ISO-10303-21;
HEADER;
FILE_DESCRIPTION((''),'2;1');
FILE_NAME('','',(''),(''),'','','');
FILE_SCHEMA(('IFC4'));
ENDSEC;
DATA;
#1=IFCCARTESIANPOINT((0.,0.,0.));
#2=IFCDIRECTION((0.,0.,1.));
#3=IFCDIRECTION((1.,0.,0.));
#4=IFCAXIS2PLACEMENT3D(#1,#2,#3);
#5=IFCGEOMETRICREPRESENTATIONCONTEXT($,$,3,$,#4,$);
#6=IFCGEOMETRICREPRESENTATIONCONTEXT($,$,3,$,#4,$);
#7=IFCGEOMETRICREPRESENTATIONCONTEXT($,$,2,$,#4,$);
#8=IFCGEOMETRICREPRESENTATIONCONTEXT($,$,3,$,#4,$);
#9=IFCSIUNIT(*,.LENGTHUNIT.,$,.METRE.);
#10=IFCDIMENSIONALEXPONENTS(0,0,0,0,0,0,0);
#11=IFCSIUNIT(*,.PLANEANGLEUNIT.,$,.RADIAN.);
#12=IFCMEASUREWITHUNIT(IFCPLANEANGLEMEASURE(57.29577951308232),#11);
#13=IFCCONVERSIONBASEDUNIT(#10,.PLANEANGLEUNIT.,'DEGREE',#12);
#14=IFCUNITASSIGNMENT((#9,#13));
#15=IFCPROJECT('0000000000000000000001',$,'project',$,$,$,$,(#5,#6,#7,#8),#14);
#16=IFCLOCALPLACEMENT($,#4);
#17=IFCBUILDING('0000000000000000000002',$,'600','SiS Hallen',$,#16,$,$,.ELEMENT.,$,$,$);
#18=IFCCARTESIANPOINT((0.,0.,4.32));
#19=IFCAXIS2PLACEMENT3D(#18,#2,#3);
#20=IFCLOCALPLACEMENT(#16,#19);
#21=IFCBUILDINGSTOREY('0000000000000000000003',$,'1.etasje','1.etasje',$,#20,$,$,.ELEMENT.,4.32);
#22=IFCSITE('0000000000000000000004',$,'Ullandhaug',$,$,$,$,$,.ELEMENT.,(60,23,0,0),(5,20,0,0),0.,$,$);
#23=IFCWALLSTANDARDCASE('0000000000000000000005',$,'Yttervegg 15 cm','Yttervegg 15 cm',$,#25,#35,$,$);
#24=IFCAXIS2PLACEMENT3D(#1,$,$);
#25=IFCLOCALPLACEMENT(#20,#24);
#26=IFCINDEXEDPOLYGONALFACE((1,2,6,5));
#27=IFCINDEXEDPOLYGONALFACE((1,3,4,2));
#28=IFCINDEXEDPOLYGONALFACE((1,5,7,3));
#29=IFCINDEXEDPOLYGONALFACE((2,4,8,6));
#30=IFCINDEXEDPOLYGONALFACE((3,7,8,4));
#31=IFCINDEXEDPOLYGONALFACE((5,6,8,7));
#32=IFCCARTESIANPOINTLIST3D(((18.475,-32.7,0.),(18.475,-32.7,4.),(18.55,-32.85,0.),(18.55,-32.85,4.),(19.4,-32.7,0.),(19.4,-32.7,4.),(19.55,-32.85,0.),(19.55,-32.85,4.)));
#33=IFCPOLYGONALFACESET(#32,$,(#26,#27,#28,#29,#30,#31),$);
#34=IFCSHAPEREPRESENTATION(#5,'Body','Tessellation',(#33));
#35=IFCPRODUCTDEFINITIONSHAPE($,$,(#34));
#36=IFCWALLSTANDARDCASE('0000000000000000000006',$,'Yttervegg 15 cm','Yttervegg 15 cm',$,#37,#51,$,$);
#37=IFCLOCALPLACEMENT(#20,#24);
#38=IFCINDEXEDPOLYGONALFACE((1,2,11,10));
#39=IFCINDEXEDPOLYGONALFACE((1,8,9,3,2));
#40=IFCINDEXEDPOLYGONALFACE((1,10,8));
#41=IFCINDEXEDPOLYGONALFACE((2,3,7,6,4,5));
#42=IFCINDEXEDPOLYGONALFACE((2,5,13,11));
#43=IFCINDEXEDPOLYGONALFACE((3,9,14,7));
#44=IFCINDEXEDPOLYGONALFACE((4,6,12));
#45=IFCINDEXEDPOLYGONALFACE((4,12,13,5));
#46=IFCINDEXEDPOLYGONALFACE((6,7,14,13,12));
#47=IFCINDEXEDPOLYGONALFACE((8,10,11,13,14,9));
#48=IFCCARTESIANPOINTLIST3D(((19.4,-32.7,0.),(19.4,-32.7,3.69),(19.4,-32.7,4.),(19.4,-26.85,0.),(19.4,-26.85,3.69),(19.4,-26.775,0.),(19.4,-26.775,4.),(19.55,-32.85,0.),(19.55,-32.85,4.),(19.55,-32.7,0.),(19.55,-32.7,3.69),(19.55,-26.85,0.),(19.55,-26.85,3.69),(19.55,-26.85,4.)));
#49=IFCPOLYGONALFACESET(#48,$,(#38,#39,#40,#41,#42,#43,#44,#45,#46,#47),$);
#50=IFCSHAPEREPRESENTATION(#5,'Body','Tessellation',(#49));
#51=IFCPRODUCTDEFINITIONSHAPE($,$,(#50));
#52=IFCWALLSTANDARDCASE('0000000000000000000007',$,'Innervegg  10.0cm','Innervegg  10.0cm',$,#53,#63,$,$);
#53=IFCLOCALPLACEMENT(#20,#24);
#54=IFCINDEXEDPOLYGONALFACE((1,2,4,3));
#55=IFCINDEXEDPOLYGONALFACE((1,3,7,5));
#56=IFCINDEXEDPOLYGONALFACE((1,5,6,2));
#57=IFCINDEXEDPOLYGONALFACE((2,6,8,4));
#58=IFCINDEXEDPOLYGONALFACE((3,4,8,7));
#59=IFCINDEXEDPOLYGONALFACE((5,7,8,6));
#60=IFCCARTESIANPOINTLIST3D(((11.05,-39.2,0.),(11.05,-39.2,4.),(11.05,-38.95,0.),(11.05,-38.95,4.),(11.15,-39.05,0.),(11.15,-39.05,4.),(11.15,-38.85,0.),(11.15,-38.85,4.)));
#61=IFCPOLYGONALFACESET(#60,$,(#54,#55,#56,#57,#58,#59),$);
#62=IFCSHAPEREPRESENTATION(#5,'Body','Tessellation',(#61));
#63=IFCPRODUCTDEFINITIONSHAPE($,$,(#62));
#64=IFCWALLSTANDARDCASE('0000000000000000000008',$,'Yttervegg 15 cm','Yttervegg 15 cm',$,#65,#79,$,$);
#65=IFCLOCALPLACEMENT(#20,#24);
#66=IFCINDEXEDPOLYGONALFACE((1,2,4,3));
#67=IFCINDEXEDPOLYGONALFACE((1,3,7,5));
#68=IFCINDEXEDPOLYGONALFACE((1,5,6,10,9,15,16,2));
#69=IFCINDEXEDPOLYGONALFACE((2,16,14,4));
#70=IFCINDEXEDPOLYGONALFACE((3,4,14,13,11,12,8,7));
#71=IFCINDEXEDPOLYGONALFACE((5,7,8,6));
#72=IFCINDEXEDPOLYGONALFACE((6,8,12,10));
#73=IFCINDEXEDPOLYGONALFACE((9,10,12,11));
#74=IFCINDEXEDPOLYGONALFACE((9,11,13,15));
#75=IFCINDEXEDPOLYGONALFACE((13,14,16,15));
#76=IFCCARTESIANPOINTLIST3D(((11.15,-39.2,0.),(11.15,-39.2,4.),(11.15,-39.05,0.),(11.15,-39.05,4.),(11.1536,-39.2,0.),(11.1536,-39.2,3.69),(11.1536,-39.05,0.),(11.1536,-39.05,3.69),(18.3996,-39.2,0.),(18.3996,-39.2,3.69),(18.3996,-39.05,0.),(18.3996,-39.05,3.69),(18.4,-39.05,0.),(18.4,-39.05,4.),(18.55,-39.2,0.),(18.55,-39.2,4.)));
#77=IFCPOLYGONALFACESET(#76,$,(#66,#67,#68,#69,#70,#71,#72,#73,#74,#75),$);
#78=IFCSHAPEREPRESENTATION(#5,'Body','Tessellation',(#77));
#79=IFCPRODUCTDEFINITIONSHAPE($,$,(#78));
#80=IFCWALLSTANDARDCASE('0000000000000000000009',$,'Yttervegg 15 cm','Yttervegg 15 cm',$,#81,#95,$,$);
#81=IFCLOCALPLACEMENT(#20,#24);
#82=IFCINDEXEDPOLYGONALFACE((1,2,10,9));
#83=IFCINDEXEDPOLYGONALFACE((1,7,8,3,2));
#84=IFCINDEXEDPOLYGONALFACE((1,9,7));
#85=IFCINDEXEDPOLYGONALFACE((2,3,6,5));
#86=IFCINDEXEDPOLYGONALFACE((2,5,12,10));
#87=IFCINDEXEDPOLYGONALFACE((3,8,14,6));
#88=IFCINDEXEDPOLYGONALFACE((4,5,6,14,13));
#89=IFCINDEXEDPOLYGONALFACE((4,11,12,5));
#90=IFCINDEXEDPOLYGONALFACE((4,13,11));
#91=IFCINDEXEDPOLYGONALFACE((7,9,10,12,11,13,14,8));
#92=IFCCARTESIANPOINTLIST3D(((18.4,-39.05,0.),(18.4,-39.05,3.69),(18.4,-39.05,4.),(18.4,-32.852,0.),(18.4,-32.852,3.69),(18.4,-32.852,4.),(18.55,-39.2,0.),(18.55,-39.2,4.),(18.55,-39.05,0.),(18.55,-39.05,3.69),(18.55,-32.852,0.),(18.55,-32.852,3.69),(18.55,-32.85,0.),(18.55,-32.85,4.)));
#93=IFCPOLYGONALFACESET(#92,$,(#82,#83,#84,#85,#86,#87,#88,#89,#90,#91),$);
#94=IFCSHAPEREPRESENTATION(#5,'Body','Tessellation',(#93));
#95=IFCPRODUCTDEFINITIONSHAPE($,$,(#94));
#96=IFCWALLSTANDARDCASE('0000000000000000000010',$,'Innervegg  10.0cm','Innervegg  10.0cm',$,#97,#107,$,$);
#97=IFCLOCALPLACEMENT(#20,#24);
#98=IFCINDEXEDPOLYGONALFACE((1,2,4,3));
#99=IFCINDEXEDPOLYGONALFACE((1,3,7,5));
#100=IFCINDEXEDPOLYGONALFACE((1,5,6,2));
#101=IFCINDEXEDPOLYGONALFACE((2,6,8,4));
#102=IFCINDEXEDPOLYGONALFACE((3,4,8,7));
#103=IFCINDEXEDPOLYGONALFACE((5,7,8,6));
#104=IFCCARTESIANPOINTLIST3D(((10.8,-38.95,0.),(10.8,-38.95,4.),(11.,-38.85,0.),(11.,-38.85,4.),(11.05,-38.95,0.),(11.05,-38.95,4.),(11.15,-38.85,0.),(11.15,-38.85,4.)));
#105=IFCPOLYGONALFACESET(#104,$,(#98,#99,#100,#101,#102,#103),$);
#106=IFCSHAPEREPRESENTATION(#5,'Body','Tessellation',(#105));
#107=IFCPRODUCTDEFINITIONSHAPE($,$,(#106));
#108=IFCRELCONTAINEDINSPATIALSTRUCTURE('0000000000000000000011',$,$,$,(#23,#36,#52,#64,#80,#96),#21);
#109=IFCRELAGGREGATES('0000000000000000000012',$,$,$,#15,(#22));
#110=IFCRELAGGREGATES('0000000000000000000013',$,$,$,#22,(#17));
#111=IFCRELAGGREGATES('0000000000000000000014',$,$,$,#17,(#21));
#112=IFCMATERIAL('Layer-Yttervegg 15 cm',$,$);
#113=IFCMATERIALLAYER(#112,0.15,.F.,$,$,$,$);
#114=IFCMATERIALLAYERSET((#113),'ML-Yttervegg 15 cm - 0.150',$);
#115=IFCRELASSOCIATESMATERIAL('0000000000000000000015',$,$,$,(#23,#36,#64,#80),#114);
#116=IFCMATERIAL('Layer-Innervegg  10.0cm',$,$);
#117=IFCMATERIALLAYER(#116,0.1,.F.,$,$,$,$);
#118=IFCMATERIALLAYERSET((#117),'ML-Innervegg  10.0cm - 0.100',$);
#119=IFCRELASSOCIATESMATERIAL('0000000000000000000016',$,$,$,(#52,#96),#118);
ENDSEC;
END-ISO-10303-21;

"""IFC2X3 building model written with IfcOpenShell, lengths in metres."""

from ifc_helpers import new_model, entity, si_unit, converted_unit, frame, origin_with_axes, place, context, project, spatial, polyline, outline, extrude, material, layer, layer_set, layer_usage, element, save


model = new_model("IFC2X3")

# Units and contexts
context_of_model_1 = context(None, 3, world=origin_with_axes())
context_of_model_2 = context(None, 3, world=origin_with_axes())
context_of_model_3 = context(None, 2, world=origin_with_axes())
context_of_model_4 = context(None, 3, world=origin_with_axes())
ifc_project = project(units=[si_unit("LENGTHUNIT", "METRE"), converted_unit("PLANEANGLEUNIT", "DEGREE", entity("IfcPlaneAngleMeasure", 57.29577951308232), si_unit("PLANEANGLEUNIT", "RADIAN"), dimensions=[0, 0, 0, 0, 0, 0, 0])], contexts=[context_of_model_1, context_of_model_2, context_of_model_3, context_of_model_4])

# Site, building, storey
site = spatial("IfcSite", under=ifc_project, Name="Ullandhaug", CompositionType="ELEMENT", RefLatitude=(60, 23, 0, 0), RefLongitude=(5, 20, 0, 0), RefElevation=0.0)
building_placement = place(None, origin_with_axes())
building = spatial("IfcBuilding", under=site, at=building_placement, Name="600", Description="SiS Hallen", CompositionType="ELEMENT")
storey_placement = place(building_placement, frame((0.0, 0.0, 4.32), z_axis=(0.0, 0.0, 1.0), x_axis=(1.0, 0.0, 0.0)))
storey = spatial("IfcBuildingStorey", under=building, at=storey_placement, Name="1.etasje", Description="1.etasje", CompositionType="ELEMENT", Elevation=4.32)

# Wall
ifc_material_1 = material(Name="Layer-Yttervegg 15 cm")
ifc_layer_1 = layer(ifc_material_1, 0.15, ventilated=False)
ifc_layer_set_1 = layer_set([ifc_layer_1], Name="ML-Yttervegg 15 cm - 0.150")
ifc_layer_usage_1 = layer_usage(ifc_layer_set_1, "AXIS2", "POSITIVE", 0.0)
wall_1_placement = place(storey_placement, frame((18.55, -32.85, 0.0), z_axis=(0.0, 0.0, 1.0), x_axis=(1.0, 0.0, 0.0)))
element("IfcWallStandardCase", 1, at=wall_1_placement, inside=storey, material=ifc_layer_usage_1, Name="Yttervegg 15 cm", Description="Yttervegg 15 cm", context=context_of_model_1, shape_type="SweptSolid", body=[
    extrude(outline(polyline([(0.0, 0.0), (1.0, 0.0), (0.85, 0.15), (-0.075, 0.15), (0.0, 0.0)])), origin_with_axes(), (0.0, 0.0, 1.0), 4.0),
])

# Wall, opening
wall_2_placement = place(storey_placement, frame((19.55, -32.85, 0.0), z_axis=(0.0, 0.0, 1.0), x_axis=(0.0, 1.0, 0.0)))
wall_2 = element("IfcWallStandardCase", 2, at=wall_2_placement, inside=storey, material=ifc_layer_usage_1, Name="Yttervegg 15 cm", Description="Yttervegg 15 cm", context=context_of_model_1, shape_type="SweptSolid", body=[
    extrude(outline(polyline([(0.0, 0.0), (6.0, 0.0), (6.075, 0.15), (0.15, 0.15), (0.0, 0.0)])), frame((0.0, 0.0, 0.0), z_axis=(0.0, 0.0, 1.0), x_axis=(1.0, 0.0, 0.0)), (0.0, 0.0, 1.0), 4.0),
])
opening_1_placement = place(wall_2_placement, frame((0.15, 0.15, 0.0), z_axis=(0.0, 0.0, 1.0), x_axis=(1.0, 0.0, 0.0)))
element("IfcOpeningElement", 3, at=opening_1_placement, cuts=wall_2, context=context_of_model_1, shape_type="SweptSolid", body=[
    extrude(outline(polyline([(0.0, 0.0), (3.69, 0.0), (3.69, 5.85), (0.0, 5.85), (0.0, 0.0)])), frame((0.0, 0.0, 0.0), z_axis=(0.0, 1.0, 0.0), x_axis=(0.0, 0.0, 1.0)), (0.0, 0.0, -1.0), 0.15),
])

# Wall
ifc_material_2 = material(Name="Layer-Innervegg  10.0cm")
ifc_layer_2 = layer(ifc_material_2, 0.1, ventilated=False)
ifc_layer_set_2 = layer_set([ifc_layer_2], Name="ML-Innervegg  10.0cm - 0.100")
ifc_layer_usage_2 = layer_usage(ifc_layer_set_2, "AXIS2", "POSITIVE", 0.0)
wall_3_placement = place(storey_placement, frame((11.05, -38.95, 0.0), z_axis=(0.0, 0.0, 1.0), x_axis=(0.0, -1.0, 0.0)))
element("IfcWallStandardCase", 4, at=wall_3_placement, inside=storey, material=ifc_layer_usage_2, Name="Innervegg  10.0cm", Description="Innervegg  10.0cm", context=context_of_model_1, shape_type="SweptSolid", body=[
    extrude(outline(polyline([(0.0, 0.0), (0.25, 0.0), (0.1, 0.1), (-0.1, 0.1), (0.0, 0.0)])), frame((0.0, 0.0, 0.0), z_axis=(0.0, 0.0, 1.0), x_axis=(1.0, 0.0, 0.0)), (0.0, 0.0, 1.0), 4.0),
])

# Walls, openings
wall_4_placement = place(storey_placement, frame((11.15, -39.2, 0.0), z_axis=(0.0, 0.0, 1.0), x_axis=(1.0, 0.0, 0.0)))
wall_4 = element("IfcWallStandardCase", 5, at=wall_4_placement, inside=storey, material=ifc_layer_usage_1, Name="Yttervegg 15 cm", Description="Yttervegg 15 cm", context=context_of_model_1, shape_type="SweptSolid", body=[
    extrude(outline(polyline([(0.0, 0.0), (7.4, 0.0), (7.25, 0.15), (0.0, 0.15), (0.0, 0.0)])), origin_with_axes(), (0.0, 0.0, 1.0), 4.0),
])
opening_2_placement = place(wall_4_placement, frame((0.0036, 0.15, 0.0), z_axis=(0.0, 0.0, 1.0), x_axis=(1.0, 0.0, 0.0)))
element("IfcOpeningElement", 6, at=opening_2_placement, cuts=wall_4, context=context_of_model_1, shape_type="SweptSolid", body=[
    extrude(outline(polyline([(0.0, 0.0), (3.69, 0.0), (3.69, 7.246), (0.0, 7.246), (0.0, 0.0)])), frame((0.0, 0.0, 0.0), z_axis=(0.0, 1.0, 0.0), x_axis=(0.0, 0.0, 1.0)), (0.0, 0.0, -1.0), 0.15),
])
wall_5_placement = place(storey_placement, frame((18.55, -39.2, 0.0), z_axis=(0.0, 0.0, 1.0), x_axis=(0.0, 1.0, 0.0)))
wall_5 = element("IfcWallStandardCase", 7, at=wall_5_placement, inside=storey, material=ifc_layer_usage_1, Name="Yttervegg 15 cm", Description="Yttervegg 15 cm", context=context_of_model_1, shape_type="SweptSolid", body=[
    extrude(outline(polyline([(0.0, 0.0), (6.35, 0.0), (6.348, 0.15), (0.15, 0.15), (0.0, 0.0)])), frame((0.0, 0.0, 0.0), z_axis=(0.0, 0.0, 1.0), x_axis=(1.0, 0.0, 0.0)), (0.0, 0.0, 1.0), 4.0),
])
opening_3_placement = place(wall_5_placement, frame((0.15, 0.15, 0.0), z_axis=(0.0, 0.0, 1.0), x_axis=(1.0, 0.0, 0.0)))
element("IfcOpeningElement", 8, at=opening_3_placement, cuts=wall_5, context=context_of_model_1, shape_type="SweptSolid", body=[
    extrude(outline(polyline([(0.0, 0.0), (3.69, 0.0), (3.69, 6.198), (0.0, 6.198), (0.0, 0.0)])), frame((0.0, 0.0, 0.0), z_axis=(0.0, 1.0, 0.0), x_axis=(0.0, 0.0, 1.0)), (0.0, 0.0, -1.0), 0.15),
])

# Wall
wall_6_placement = place(storey_placement, frame((10.8, -38.95, 0.0), z_axis=(0.0, 0.0, 1.0), x_axis=(1.0, 0.0, 0.0)))
element("IfcWallStandardCase", 9, at=wall_6_placement, inside=storey, material=ifc_layer_usage_2, Name="Innervegg  10.0cm", Description="Innervegg  10.0cm", context=context_of_model_1, shape_type="SweptSolid", body=[
    extrude(outline(polyline([(0.0, 0.0), (0.25, 0.0), (0.35, 0.1), (0.2, 0.1), (0.0, 0.0)])), origin_with_axes(), (0.0, 0.0, 1.0), 4.0),
])

save(model, "model.ifc")
